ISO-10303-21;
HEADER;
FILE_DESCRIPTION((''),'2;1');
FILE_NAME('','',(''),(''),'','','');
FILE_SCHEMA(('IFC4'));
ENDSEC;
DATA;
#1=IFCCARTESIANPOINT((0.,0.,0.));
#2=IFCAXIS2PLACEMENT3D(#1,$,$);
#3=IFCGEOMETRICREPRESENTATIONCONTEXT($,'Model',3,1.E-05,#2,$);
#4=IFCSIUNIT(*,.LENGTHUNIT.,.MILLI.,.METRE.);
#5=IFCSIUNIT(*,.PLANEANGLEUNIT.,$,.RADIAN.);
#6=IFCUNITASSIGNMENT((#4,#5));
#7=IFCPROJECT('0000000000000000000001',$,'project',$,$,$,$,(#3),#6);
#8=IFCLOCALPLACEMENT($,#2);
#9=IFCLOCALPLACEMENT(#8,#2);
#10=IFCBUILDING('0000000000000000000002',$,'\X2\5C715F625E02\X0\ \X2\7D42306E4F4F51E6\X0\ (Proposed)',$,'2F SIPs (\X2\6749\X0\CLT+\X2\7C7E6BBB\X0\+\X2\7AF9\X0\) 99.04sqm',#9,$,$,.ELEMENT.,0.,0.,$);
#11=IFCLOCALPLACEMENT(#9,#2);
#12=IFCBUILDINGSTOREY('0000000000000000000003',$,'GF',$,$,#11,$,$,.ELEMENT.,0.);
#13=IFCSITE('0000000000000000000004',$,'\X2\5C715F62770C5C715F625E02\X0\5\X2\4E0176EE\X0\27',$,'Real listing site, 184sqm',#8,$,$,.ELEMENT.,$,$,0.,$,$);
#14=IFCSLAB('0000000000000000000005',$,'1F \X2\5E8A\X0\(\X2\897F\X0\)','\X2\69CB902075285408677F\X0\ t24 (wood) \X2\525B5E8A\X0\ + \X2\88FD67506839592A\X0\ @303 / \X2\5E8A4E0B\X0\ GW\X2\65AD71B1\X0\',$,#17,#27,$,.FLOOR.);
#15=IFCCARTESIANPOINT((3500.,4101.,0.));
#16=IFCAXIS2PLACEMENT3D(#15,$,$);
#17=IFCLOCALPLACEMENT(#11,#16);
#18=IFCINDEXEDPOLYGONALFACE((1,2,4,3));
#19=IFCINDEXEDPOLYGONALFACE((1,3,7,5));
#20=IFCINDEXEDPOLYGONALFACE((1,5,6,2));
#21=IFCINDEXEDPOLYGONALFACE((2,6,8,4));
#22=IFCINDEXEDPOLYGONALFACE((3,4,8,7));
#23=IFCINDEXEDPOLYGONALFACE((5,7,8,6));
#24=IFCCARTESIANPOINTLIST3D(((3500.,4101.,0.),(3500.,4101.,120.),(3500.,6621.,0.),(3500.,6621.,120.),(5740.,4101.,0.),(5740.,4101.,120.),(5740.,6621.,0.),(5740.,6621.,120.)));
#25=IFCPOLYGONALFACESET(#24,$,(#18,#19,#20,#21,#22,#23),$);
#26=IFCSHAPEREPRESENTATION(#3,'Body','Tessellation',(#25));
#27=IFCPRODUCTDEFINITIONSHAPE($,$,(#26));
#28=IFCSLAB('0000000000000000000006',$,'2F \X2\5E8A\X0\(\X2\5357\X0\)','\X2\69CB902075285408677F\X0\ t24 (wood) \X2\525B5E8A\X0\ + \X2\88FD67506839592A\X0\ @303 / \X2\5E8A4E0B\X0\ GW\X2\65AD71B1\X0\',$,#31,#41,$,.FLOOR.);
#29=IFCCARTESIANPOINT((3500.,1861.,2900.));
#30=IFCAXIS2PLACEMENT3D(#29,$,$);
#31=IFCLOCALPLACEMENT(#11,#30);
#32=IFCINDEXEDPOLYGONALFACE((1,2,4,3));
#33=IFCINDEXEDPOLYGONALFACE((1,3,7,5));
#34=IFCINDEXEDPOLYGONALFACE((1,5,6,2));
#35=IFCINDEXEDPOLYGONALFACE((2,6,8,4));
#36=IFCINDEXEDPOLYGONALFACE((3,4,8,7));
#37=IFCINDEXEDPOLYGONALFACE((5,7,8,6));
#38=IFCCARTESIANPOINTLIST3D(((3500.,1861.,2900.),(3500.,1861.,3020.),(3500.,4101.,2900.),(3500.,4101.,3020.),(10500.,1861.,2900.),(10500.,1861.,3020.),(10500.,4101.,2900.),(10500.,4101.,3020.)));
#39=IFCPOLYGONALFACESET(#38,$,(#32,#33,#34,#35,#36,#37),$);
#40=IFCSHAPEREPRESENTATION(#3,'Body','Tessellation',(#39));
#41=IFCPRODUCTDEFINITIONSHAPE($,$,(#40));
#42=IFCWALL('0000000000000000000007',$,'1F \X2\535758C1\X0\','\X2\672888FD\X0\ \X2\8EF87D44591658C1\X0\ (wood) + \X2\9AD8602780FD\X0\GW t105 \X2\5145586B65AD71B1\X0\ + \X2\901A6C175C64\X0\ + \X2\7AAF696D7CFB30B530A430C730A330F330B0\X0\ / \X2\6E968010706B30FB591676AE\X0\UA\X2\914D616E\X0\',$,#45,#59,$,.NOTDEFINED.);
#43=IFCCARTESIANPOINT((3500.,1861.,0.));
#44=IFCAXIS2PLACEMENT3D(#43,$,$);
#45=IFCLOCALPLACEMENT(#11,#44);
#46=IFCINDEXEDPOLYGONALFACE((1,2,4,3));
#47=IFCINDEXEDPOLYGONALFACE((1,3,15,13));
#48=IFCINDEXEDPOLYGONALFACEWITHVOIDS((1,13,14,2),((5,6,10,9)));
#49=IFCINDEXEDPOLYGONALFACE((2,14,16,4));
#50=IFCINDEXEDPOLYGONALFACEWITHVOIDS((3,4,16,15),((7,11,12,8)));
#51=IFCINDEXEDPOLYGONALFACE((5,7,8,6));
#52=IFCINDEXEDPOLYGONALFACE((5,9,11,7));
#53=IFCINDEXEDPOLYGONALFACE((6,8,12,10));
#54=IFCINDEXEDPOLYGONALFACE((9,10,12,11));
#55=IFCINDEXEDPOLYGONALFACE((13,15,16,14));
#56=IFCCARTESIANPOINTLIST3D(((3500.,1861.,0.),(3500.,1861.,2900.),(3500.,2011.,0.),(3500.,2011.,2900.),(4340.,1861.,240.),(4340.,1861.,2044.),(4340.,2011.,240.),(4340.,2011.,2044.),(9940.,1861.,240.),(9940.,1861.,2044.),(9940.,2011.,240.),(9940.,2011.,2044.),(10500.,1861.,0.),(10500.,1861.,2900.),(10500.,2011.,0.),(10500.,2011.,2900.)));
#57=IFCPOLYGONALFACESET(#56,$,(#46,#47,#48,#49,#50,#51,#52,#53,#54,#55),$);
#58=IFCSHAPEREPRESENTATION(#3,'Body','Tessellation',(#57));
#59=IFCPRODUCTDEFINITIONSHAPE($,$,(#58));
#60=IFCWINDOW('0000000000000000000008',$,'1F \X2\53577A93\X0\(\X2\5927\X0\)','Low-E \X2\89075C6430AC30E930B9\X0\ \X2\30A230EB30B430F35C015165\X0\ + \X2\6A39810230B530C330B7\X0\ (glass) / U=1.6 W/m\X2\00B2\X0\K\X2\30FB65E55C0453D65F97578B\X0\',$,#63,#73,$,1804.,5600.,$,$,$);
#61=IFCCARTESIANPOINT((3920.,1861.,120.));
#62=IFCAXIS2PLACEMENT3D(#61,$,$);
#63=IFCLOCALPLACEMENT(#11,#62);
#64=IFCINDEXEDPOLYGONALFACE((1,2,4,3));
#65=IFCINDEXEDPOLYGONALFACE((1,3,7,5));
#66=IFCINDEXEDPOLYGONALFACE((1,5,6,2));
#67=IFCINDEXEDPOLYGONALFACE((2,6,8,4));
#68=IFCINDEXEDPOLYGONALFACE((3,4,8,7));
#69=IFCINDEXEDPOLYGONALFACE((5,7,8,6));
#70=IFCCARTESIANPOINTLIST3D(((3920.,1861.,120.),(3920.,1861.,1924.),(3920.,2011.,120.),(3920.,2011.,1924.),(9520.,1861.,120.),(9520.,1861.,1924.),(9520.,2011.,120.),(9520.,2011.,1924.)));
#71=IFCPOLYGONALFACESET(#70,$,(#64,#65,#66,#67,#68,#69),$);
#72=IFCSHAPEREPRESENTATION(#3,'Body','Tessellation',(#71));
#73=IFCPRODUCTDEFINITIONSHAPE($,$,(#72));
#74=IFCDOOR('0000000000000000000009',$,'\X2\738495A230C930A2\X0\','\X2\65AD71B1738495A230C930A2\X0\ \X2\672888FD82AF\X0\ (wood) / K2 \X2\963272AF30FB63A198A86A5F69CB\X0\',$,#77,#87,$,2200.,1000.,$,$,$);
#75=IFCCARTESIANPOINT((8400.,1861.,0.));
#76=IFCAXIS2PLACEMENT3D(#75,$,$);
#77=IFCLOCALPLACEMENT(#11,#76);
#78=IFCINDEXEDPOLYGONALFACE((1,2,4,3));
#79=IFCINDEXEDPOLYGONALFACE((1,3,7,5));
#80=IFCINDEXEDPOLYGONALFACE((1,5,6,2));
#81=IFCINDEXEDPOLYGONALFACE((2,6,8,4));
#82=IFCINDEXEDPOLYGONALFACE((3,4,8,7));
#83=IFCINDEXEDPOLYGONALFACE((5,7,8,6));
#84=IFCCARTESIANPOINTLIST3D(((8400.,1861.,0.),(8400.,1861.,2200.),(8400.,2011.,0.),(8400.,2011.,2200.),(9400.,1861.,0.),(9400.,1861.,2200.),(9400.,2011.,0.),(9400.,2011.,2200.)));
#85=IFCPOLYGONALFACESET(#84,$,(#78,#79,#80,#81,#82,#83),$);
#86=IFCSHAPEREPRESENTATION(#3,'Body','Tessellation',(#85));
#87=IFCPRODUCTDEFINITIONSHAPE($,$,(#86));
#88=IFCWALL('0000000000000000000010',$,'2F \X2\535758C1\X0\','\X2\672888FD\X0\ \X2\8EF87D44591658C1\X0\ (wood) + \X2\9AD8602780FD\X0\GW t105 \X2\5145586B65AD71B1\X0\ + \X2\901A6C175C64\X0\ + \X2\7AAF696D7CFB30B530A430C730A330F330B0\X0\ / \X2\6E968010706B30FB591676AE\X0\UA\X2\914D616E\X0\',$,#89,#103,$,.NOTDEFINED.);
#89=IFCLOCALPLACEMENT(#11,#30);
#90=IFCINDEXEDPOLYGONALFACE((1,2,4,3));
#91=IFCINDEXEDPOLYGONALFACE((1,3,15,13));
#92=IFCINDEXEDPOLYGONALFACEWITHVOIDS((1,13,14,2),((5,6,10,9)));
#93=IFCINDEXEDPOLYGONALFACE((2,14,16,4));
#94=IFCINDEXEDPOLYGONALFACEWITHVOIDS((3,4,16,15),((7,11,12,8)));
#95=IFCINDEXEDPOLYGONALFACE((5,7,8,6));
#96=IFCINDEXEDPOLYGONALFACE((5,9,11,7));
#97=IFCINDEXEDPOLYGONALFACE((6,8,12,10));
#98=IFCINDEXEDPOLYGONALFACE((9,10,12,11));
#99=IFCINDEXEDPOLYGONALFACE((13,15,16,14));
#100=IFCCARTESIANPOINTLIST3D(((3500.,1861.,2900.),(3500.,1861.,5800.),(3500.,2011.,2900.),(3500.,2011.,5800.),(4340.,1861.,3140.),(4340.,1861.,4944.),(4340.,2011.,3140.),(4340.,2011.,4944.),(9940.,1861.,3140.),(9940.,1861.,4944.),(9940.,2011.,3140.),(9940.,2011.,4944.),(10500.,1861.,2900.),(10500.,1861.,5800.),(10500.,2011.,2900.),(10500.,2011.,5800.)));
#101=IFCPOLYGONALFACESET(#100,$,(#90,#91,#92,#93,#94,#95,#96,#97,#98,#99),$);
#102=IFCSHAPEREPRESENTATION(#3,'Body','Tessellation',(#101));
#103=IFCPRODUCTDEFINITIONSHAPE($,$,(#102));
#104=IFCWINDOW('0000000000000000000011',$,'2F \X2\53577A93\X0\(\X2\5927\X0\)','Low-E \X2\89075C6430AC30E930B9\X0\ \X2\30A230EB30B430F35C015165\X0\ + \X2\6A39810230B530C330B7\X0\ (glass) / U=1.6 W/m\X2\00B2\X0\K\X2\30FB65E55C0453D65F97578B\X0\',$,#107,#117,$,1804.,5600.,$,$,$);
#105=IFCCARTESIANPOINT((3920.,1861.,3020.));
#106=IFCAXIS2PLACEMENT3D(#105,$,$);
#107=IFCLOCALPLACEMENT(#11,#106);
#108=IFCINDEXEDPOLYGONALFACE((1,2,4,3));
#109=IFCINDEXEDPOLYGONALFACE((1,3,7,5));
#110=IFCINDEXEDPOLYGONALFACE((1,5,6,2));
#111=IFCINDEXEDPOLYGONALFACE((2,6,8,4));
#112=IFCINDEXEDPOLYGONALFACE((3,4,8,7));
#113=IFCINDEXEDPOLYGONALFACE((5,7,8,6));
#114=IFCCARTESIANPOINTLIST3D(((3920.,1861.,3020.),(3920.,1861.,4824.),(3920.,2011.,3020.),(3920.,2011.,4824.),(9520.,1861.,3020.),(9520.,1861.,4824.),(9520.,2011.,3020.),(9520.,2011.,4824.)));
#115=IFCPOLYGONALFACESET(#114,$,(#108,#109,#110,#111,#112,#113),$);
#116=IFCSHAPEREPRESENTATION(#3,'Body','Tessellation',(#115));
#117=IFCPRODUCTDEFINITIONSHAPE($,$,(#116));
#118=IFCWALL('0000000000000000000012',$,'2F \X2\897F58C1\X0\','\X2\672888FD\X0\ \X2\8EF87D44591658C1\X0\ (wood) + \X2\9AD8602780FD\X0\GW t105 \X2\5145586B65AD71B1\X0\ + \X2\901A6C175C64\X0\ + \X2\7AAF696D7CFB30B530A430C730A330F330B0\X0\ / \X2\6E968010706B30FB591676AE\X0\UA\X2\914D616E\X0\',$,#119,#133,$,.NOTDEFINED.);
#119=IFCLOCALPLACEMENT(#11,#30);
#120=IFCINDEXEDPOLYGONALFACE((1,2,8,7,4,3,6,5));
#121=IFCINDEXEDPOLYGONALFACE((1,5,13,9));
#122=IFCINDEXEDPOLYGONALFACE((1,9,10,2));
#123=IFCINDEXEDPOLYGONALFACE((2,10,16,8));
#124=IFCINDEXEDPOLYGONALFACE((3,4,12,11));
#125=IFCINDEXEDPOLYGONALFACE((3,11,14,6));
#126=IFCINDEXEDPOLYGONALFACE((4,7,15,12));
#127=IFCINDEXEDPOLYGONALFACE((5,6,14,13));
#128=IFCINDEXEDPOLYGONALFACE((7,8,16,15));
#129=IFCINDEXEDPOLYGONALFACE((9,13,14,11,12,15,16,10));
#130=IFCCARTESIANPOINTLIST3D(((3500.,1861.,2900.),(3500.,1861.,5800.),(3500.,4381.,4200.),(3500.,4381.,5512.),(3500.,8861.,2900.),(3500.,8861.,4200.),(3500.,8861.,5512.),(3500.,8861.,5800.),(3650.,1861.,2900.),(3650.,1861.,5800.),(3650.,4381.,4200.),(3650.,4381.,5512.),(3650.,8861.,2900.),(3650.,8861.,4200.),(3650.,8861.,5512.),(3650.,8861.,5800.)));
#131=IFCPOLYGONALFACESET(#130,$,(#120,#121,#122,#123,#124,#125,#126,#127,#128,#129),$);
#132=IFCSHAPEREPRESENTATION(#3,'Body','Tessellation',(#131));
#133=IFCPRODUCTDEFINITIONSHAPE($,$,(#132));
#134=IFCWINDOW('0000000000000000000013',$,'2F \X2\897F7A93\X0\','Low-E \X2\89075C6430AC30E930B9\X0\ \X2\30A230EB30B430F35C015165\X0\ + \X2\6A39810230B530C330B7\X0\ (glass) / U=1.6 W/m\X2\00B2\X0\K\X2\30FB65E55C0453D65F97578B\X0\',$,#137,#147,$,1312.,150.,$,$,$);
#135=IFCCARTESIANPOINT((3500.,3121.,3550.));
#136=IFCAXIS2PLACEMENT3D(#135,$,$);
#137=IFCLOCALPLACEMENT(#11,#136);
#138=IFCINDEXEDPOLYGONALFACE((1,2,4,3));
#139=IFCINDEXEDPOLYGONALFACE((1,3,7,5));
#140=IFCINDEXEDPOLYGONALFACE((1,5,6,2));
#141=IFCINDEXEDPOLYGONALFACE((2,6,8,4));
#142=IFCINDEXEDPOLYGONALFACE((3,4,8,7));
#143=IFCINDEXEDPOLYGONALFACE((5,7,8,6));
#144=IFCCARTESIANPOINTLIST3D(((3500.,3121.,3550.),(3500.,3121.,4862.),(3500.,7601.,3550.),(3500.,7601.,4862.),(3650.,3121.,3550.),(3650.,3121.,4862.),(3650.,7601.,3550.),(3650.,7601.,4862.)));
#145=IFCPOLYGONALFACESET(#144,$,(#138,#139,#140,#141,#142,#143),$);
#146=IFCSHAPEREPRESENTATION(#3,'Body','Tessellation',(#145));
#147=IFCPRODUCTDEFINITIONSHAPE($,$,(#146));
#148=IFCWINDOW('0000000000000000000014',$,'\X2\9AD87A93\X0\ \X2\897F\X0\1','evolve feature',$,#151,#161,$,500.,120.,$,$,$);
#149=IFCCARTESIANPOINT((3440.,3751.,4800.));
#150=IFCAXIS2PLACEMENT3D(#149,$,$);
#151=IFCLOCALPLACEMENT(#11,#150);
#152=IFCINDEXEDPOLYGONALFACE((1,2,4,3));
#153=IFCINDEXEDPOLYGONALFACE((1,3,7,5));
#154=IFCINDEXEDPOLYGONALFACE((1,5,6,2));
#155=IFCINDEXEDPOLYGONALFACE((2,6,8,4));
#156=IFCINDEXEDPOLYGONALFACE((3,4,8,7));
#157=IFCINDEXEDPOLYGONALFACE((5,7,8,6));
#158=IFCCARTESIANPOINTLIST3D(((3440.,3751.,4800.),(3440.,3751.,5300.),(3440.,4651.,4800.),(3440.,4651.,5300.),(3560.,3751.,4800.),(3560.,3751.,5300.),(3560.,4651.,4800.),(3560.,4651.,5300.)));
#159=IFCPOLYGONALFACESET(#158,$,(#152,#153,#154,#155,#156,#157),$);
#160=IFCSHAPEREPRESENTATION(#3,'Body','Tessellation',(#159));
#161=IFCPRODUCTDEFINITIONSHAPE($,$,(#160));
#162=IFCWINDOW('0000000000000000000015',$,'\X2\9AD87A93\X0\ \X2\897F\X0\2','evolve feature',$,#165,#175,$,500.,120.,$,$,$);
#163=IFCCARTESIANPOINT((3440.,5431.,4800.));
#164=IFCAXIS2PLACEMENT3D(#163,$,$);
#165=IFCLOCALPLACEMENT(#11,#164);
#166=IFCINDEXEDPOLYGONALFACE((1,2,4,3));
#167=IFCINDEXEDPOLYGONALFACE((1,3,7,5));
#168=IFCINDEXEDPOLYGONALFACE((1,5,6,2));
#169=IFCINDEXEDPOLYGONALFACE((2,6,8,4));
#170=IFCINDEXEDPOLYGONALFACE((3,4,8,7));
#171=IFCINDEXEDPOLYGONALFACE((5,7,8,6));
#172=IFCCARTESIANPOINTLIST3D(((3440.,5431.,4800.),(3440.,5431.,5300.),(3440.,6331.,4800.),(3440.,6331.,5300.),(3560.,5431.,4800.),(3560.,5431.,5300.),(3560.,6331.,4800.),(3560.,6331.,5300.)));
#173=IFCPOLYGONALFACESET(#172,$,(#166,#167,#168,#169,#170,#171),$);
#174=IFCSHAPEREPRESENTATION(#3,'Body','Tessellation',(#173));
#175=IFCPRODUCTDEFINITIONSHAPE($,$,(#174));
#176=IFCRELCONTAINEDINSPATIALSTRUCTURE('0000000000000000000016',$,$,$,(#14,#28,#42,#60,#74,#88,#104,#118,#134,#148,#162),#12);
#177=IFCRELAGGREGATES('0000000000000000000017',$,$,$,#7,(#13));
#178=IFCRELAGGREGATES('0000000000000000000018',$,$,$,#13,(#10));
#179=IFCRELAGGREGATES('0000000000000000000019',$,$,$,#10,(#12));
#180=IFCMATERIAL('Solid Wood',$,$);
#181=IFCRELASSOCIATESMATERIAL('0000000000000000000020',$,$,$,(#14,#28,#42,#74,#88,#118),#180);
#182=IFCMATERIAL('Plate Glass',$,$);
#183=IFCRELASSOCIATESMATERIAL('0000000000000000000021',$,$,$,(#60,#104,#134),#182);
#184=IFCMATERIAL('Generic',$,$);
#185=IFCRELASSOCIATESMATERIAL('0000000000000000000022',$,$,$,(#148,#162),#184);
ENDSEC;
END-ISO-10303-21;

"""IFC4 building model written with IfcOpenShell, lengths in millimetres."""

from ifc_helpers import new_model, si_unit, frame, frame_2d, origin, place, context, project, spatial, rectangle, extrude, material, element, fill, save


model = new_model("IFC4")

# Units and contexts
model_context = context("Model", 3, precision=1e-05, world=origin())
ifc_project = project(units=[si_unit("LENGTHUNIT", "METRE", prefix="MILLI"), si_unit("PLANEANGLEUNIT", "RADIAN")], contexts=[model_context])

# Site, building, storey
site_placement = place(None, origin())
site = spatial("IfcSite", under=ifc_project, at=site_placement, Name="山形県山形市5丁目27", ObjectType="Real listing site, 184sqm", CompositionType="ELEMENT", RefElevation=0.0)
building_placement = place(site_placement, origin())
building = spatial("IfcBuilding", under=site, at=building_placement, Name="山形市 終の住処 (Proposed)", ObjectType="2F SIPs (杉CLT+籾殻+竹) 99.04sqm", CompositionType="ELEMENT", ElevationOfRefHeight=0.0, ElevationOfTerrain=0.0)
storey_placement = place(building_placement, origin())
storey = spatial("IfcBuildingStorey", under=building, at=storey_placement, Name="GF", CompositionType="ELEMENT", Elevation=0.0)

# Slabs
ifc_material_1 = material(Name="Solid Wood")
slab_1_placement = place(storey_placement, frame((3500.0, 4101.0, 0.0)))
element("IfcSlab", 1, at=slab_1_placement, inside=storey, material=ifc_material_1, Name="1F 床(西)", Description="構造用合板 t24 (wood) 剛床 + 製材根太 @303 / 床下 GW断熱", PredefinedType="FLOOR", context=model_context, shape_type="SweptSolid", body=[
    extrude(rectangle(XDim=2240.0, YDim=2520.0, at=frame_2d((1120.0, 1260.0))), frame((3500.0, 4101.0, 0.0)), (0.0, 0.0, 1.0), 120.0),
])
slab_2_placement = place(storey_placement, frame((3500.0, 1861.0, 2900.0)))
element("IfcSlab", 2, at=slab_2_placement, inside=storey, material=ifc_material_1, Name="2F 床(南)", Description="構造用合板 t24 (wood) 剛床 + 製材根太 @303 / 床下 GW断熱", PredefinedType="FLOOR", context=model_context, shape_type="SweptSolid", body=[
    extrude(rectangle(XDim=7000.0, YDim=2240.0, at=frame_2d((3500.0, 1120.0))), frame((3500.0, 1861.0, 2900.0)), (0.0, 0.0, 1.0), 120.0),
])
ifc_material_2 = material(Name="Generic")

# Wall, openings, window, door
wall_1_placement = place(storey_placement, frame((3500.0, 1861.0, 0.0)))
wall_1 = element("IfcWall", 3, at=wall_1_placement, inside=storey, material=ifc_material_1, Name="1F 南壁", Description="木製 軸組外壁 (wood) + 高性能GW t105 充填断熱 + 通気層 + 窯業系サイディング / 準耐火・外皮UA配慮", PredefinedType="NOTDEFINED", context=model_context, shape_type="SweptSolid", body=[
    extrude(rectangle(XDim=7000.0, YDim=150.0, at=frame_2d((3500.0, 75.0))), frame((3500.0, 1861.0, 0.0)), (0.0, 0.0, 1.0), 2900.0),
])
opening_1_placement = place(storey_placement, frame((3920.0, 1861.0, 120.0)))
opening_1 = element("IfcOpeningElement", 4, at=opening_1_placement, cuts=wall_1, PredefinedType="NOTDEFINED", context=model_context, shape_type="SweptSolid", body=[
    extrude(rectangle(XDim=5600.0, YDim=150.0, at=frame_2d((2800.0, 75.0))), frame((3920.0, 1861.0, 120.0)), (0.0, 0.0, 1.0), 1804.0),
])
opening_2_placement = place(storey_placement, frame((8400.0, 1861.0, 0.0)))
opening_2 = element("IfcOpeningElement", 5, at=opening_2_placement, cuts=wall_1, PredefinedType="NOTDEFINED", context=model_context, shape_type="SweptSolid", body=[
    extrude(rectangle(XDim=1000.0, YDim=150.0, at=frame_2d((500.0, 75.0))), frame((8400.0, 1861.0, 0.0)), (0.0, 0.0, 1.0), 2200.0),
])
ifc_material_3 = material(Name="Plate Glass")
window_1_placement = place(storey_placement, frame((3920.0, 1861.0, 120.0)))
window_1 = element("IfcWindow", 6, at=window_1_placement, inside=storey, material=ifc_material_3, Name="1F 南窓(大)", Description="Low-E 複層ガラス アルゴン封入 + 樹脂サッシ (glass) / U=1.6 W/m²K・日射取得型", OverallHeight=1804.0, OverallWidth=5600.0, context=model_context, shape_type="SweptSolid", body=[
    extrude(rectangle(XDim=5600.0, YDim=150.0, at=frame_2d((2800.0, 75.0))), frame((3920.0, 1861.0, 120.0)), (0.0, 0.0, 1.0), 1804.0),
])
fill(opening_1, window_1)
door_placement = place(storey_placement, frame((8400.0, 1861.0, 0.0)))
door = element("IfcDoor", 7, at=door_placement, inside=storey, material=ifc_material_1, Name="玄関ドア", Description="断熱玄関ドア 木製芯 (wood) / K2 防犯・採風機構", OverallHeight=2200.0, OverallWidth=1000.0, context=model_context, shape_type="SweptSolid", body=[
    extrude(rectangle(XDim=1000.0, YDim=150.0, at=frame_2d((500.0, 75.0))), frame((8400.0, 1861.0, 0.0)), (0.0, 0.0, 1.0), 2200.0),
])
fill(opening_2, door)

# Wall, opening, window
wall_2_placement = place(storey_placement, frame((3500.0, 1861.0, 2900.0)))
wall_2 = element("IfcWall", 8, at=wall_2_placement, inside=storey, material=ifc_material_1, Name="2F 南壁", Description="木製 軸組外壁 (wood) + 高性能GW t105 充填断熱 + 通気層 + 窯業系サイディング / 準耐火・外皮UA配慮", PredefinedType="NOTDEFINED", context=model_context, shape_type="SweptSolid", body=[
    extrude(rectangle(XDim=7000.0, YDim=150.0, at=frame_2d((3500.0, 75.0))), frame((3500.0, 1861.0, 2900.0)), (0.0, 0.0, 1.0), 2900.0),
])
opening_3_placement = place(storey_placement, frame((3920.0, 1861.0, 3020.0)))
opening_3 = element("IfcOpeningElement", 9, at=opening_3_placement, cuts=wall_2, PredefinedType="NOTDEFINED", context=model_context, shape_type="SweptSolid", body=[
    extrude(rectangle(XDim=5600.0, YDim=150.0, at=frame_2d((2800.0, 75.0))), frame((3920.0, 1861.0, 3020.0)), (0.0, 0.0, 1.0), 1804.0),
])
window_2_placement = place(storey_placement, frame((3920.0, 1861.0, 3020.0)))
window_2 = element("IfcWindow", 10, at=window_2_placement, inside=storey, material=ifc_material_3, Name="2F 南窓(大)", Description="Low-E 複層ガラス アルゴン封入 + 樹脂サッシ (glass) / U=1.6 W/m²K・日射取得型", OverallHeight=1804.0, OverallWidth=5600.0, context=model_context, shape_type="SweptSolid", body=[
    extrude(rectangle(XDim=5600.0, YDim=150.0, at=frame_2d((2800.0, 75.0))), frame((3920.0, 1861.0, 3020.0)), (0.0, 0.0, 1.0), 1804.0),
])
fill(opening_3, window_2)

# Wall, openings, windows
wall_3_placement = place(storey_placement, frame((3500.0, 1861.0, 2900.0)))
wall_3 = element("IfcWall", 11, at=wall_3_placement, inside=storey, material=ifc_material_1, Name="2F 西壁", Description="木製 軸組外壁 (wood) + 高性能GW t105 充填断熱 + 通気層 + 窯業系サイディング / 準耐火・外皮UA配慮", PredefinedType="NOTDEFINED", context=model_context, shape_type="SweptSolid", body=[
    extrude(rectangle(XDim=150.0, YDim=7000.0, at=frame_2d((75.0, 3500.0))), frame((3500.0, 1861.0, 2900.0)), (0.0, 0.0, 1.0), 2900.0),
])
opening_4_placement = place(storey_placement, frame((3500.0, 3121.0, 3550.0)))
opening_4 = element("IfcOpeningElement", 12, at=opening_4_placement, cuts=wall_3, PredefinedType="NOTDEFINED", context=model_context, shape_type="SweptSolid", body=[
    extrude(rectangle(XDim=150.0, YDim=4480.0, at=frame_2d((75.0, 2240.0))), frame((3500.0, 3121.0, 3550.0)), (0.0, 0.0, 1.0), 1312.0),
])
opening_5_placement = place(storey_placement, frame((3440.0, 3751.0, 4800.0)))
opening_5 = element("IfcOpeningElement", 13, at=opening_5_placement, cuts=wall_3, PredefinedType="NOTDEFINED", context=model_context, shape_type="SweptSolid", body=[
    extrude(rectangle(XDim=120.0, YDim=900.0, at=frame_2d((60.0, 450.0))), frame((3440.0, 3751.0, 4800.0)), (0.0, 0.0, 1.0), 500.0),
])
opening_6_placement = place(storey_placement, frame((3440.0, 5431.0, 4800.0)))
opening_6 = element("IfcOpeningElement", 14, at=opening_6_placement, cuts=wall_3, PredefinedType="NOTDEFINED", context=model_context, shape_type="SweptSolid", body=[
    extrude(rectangle(XDim=120.0, YDim=900.0, at=frame_2d((60.0, 450.0))), frame((3440.0, 5431.0, 4800.0)), (0.0, 0.0, 1.0), 500.0),
])
window_3_placement = place(storey_placement, frame((3500.0, 3121.0, 3550.0)))
window_3 = element("IfcWindow", 15, at=window_3_placement, inside=storey, material=ifc_material_3, Name="2F 西窓", Description="Low-E 複層ガラス アルゴン封入 + 樹脂サッシ (glass) / U=1.6 W/m²K・日射取得型", OverallHeight=1312.0, OverallWidth=150.0, context=model_context, shape_type="SweptSolid", body=[
    extrude(rectangle(XDim=150.0, YDim=4480.0, at=frame_2d((75.0, 2240.0))), frame((3500.0, 3121.0, 3550.0)), (0.0, 0.0, 1.0), 1312.0),
])
fill(opening_4, window_3)
window_4_placement = place(storey_placement, frame((3440.0, 3751.0, 4800.0)))
window_4 = element("IfcWindow", 16, at=window_4_placement, inside=storey, material=ifc_material_2, Name="高窓 西1", Description="evolve feature", OverallHeight=500.0, OverallWidth=120.0, context=model_context, shape_type="SweptSolid", body=[
    extrude(rectangle(XDim=120.0, YDim=900.0, at=frame_2d((60.0, 450.0))), frame((3440.0, 3751.0, 4800.0)), (0.0, 0.0, 1.0), 500.0),
])
fill(opening_5, window_4)
window_5_placement = place(storey_placement, frame((3440.0, 5431.0, 4800.0)))
window_5 = element("IfcWindow", 17, at=window_5_placement, inside=storey, material=ifc_material_2, Name="高窓 西2", Description="evolve feature", OverallHeight=500.0, OverallWidth=120.0, context=model_context, shape_type="SweptSolid", body=[
    extrude(rectangle(XDim=120.0, YDim=900.0, at=frame_2d((60.0, 450.0))), frame((3440.0, 5431.0, 4800.0)), (0.0, 0.0, 1.0), 500.0),
])
fill(opening_6, window_5)

save(model, "model.ifc")
